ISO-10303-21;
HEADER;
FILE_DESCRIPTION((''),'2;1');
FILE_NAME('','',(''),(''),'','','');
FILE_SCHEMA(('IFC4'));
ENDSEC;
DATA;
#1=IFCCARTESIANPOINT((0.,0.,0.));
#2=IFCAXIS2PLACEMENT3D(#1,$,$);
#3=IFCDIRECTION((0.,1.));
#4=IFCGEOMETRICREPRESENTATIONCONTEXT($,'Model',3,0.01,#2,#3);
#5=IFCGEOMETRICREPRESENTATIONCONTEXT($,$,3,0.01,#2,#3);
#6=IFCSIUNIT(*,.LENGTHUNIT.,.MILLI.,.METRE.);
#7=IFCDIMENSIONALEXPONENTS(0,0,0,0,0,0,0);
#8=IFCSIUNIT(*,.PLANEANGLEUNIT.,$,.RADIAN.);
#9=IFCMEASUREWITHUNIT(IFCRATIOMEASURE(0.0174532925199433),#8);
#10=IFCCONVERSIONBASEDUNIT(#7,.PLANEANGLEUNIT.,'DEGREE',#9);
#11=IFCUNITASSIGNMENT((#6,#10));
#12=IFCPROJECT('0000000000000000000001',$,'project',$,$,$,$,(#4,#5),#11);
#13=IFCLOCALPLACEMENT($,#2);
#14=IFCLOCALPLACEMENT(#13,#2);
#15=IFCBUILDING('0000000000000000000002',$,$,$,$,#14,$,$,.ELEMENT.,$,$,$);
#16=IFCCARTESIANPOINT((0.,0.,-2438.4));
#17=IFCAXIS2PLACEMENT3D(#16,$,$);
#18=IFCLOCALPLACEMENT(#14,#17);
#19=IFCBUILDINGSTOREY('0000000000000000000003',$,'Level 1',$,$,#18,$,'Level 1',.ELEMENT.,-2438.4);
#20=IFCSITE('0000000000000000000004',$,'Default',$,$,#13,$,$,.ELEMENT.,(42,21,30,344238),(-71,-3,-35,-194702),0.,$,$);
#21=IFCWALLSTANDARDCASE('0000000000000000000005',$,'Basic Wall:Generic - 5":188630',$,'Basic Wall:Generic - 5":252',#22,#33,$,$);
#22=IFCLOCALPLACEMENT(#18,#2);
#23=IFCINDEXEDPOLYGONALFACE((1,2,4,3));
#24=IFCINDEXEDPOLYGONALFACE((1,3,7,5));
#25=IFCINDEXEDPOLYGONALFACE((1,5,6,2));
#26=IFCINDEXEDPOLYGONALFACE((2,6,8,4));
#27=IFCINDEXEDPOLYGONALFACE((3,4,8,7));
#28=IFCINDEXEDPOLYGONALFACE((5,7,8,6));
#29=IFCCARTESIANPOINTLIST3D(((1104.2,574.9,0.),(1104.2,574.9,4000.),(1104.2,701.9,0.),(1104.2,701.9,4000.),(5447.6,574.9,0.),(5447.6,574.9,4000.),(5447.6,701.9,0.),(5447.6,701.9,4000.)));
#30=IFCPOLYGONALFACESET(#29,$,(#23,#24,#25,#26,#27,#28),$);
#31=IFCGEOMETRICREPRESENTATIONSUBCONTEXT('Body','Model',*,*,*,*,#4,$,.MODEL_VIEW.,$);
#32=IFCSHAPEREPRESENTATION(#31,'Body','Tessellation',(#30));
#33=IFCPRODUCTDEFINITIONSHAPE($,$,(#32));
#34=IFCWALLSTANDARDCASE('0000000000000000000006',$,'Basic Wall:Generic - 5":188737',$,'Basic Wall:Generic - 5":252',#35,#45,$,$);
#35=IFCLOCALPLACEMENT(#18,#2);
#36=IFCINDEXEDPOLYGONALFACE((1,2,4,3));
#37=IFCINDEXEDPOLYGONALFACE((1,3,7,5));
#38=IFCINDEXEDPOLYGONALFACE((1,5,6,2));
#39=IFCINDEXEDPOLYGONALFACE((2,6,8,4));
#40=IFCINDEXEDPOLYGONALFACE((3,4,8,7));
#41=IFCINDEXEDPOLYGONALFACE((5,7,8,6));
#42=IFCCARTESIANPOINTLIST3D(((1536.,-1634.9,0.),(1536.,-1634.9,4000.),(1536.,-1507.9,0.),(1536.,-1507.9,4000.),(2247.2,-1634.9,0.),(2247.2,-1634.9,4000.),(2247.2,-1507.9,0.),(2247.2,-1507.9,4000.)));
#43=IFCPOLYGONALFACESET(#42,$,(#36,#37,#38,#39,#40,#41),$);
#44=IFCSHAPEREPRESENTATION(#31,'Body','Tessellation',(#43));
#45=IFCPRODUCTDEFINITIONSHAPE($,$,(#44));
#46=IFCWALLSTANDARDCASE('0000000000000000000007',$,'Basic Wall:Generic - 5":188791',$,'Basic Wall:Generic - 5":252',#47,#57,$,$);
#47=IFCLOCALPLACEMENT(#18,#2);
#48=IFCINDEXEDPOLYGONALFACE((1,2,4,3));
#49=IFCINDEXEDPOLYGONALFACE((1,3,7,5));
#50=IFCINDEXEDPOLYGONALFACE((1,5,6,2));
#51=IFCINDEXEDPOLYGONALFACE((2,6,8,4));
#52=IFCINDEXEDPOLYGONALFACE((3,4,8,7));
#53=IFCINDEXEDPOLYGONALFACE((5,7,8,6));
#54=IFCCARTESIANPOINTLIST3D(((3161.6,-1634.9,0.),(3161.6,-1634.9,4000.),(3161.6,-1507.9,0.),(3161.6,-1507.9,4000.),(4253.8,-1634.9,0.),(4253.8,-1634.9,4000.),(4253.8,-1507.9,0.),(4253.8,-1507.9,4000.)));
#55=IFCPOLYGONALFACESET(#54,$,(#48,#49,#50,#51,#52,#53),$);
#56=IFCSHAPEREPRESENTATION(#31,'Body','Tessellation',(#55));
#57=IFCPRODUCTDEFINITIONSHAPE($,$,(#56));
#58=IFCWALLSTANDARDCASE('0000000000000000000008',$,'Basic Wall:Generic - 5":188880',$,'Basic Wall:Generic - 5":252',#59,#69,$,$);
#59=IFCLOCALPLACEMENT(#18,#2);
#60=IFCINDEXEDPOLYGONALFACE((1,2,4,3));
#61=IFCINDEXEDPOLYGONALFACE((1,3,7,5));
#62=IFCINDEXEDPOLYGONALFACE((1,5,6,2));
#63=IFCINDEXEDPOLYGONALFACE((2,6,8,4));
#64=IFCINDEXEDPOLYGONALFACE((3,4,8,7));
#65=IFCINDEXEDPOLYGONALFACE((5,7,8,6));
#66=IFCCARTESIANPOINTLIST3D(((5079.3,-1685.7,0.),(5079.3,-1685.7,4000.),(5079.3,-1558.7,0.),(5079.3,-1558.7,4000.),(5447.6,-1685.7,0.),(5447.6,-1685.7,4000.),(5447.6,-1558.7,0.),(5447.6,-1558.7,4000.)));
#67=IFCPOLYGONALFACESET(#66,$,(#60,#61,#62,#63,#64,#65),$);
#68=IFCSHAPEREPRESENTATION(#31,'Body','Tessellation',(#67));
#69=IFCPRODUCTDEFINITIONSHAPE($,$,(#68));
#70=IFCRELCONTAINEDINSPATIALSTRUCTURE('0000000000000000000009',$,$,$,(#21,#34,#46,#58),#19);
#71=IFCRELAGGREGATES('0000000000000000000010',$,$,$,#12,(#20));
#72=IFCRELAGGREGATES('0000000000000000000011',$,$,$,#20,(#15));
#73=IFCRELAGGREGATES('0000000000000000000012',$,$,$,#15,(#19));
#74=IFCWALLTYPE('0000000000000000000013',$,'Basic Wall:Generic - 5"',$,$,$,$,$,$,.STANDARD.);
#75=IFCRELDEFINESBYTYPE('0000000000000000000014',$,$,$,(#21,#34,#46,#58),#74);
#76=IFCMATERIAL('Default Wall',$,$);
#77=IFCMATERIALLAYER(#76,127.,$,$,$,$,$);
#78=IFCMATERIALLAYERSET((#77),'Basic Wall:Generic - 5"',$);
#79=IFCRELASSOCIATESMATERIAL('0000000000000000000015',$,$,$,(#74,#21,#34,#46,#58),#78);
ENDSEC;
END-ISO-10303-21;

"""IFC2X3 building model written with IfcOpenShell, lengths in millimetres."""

from ifc_helpers import new_model, entity, si_unit, converted_unit, direction, frame, frame_2d, origin, place, context, subcontext, project, spatial, polyline, rectangle, extrude, clip, bounded_halfspace, material, layer, layer_set, layer_usage, type_object, element, save


model = new_model("IFC2X3")

# Units and contexts
model_context = context("Model", 3, precision=0.01, world=origin(), true_north=direction((0.0, 1.0)))
context_of_model = context(None, 3, precision=0.01, world=origin(), true_north=direction((0.0, 1.0)))
body_context = subcontext(model_context, "Body", "Model", "MODEL_VIEW")
ifc_project = project(units=[si_unit("LENGTHUNIT", "METRE", prefix="MILLI"), converted_unit("PLANEANGLEUNIT", "DEGREE", entity("IfcRatioMeasure", 0.0174532925199433), si_unit("PLANEANGLEUNIT", "RADIAN"), dimensions=[0, 0, 0, 0, 0, 0, 0])], contexts=[model_context, context_of_model])

# Site, building, storey
site_placement = place(None, origin())
site = spatial("IfcSite", under=ifc_project, at=site_placement, Name="Default", CompositionType="ELEMENT", RefLatitude=(42, 21, 30, 344238), RefLongitude=(-71, -3, -35, -194702), RefElevation=0.0)
building_placement = place(site_placement, origin())
building = spatial("IfcBuilding", under=site, at=building_placement, CompositionType="ELEMENT")
storey_placement = place(building_placement, frame((0.0, 0.0, -2438.4)))
storey = spatial("IfcBuildingStorey", under=building, at=storey_placement, Name="Level 1", LongName="Level 1", CompositionType="ELEMENT", Elevation=-2438.4)

# Shared definitions
ifc_material_1 = material(Name="Default Wall")
ifc_layer_1 = layer(ifc_material_1, 127.0)
ifc_layer_set_1 = layer_set([ifc_layer_1], Name="Basic Wall:Generic - 5\"")
wall_type = type_object("IfcWallType", Name="Basic Wall:Generic - 5\"", PredefinedType="STANDARD", material=ifc_layer_set_1)

# Walls
ifc_layer_usage_1 = layer_usage(ifc_layer_set_1, "AXIS2", "NEGATIVE", 63.5)
wall_1_placement = place(storey_placement, frame((1104.2, 638.4, 0.0)))
element("IfcWallStandardCase", 1, at=wall_1_placement, inside=storey, type_object=wall_type, material=ifc_layer_usage_1, Name="Basic Wall:Generic - 5\":188630", ObjectType="Basic Wall:Generic - 5\":252", context=body_context, shape_type="Clipping", body=[
    clip(extrude(rectangle(XDim=4343.4, YDim=127.0, at=frame_2d((2171.7, 0.0), x_axis=(-1.0, 0.0))), origin(), (0.0, 0.0, 1.0), 4000.0), bounded_halfspace(frame((0.0, -63.5, 4000.0), z_axis=(0.0, 0.0, -1.0), x_axis=(0.0, -1.0, 0.0)), True, frame((0.0, -63.5, 4000.0)), polyline([(0.0, 0.0), (304.8, 0.0), (431.8, 0.0), (3149.6, 0.0), (3276.6, 0.0), (4343.4, 0.0), (4343.4, 127.0), (0.0, 127.0), (0.0, 0.0)]))),
])
ifc_layer_usage_2 = layer_usage(ifc_layer_set_1, "AXIS2", "NEGATIVE", 63.5)
wall_2_placement = place(storey_placement, frame((2247.2, -1571.4, 0.0), z_axis=(0.0, 0.0, 1.0), x_axis=(-1.0, 0.0, 0.0)))
element("IfcWallStandardCase", 2, at=wall_2_placement, inside=storey, type_object=wall_type, material=ifc_layer_usage_2, Name="Basic Wall:Generic - 5\":188737", ObjectType="Basic Wall:Generic - 5\":252", context=body_context, shape_type="Clipping", body=[
    clip(extrude(rectangle(XDim=711.2, YDim=127.0, at=frame_2d((355.6, 0.0), x_axis=(-1.0, 0.0))), origin(), (0.0, 0.0, 1.0), 4000.0), bounded_halfspace(frame((0.0, -63.5, 4000.0), z_axis=(0.0, 0.0, -1.0), x_axis=(0.0, 1.0, 0.0)), True, frame((0.0, -63.5, 4000.0)), polyline([(0.0, 0.0), (711.2, 0.0), (711.2, 127.0), (0.0, 127.0), (0.0, 0.0)]))),
])
ifc_layer_usage_3 = layer_usage(ifc_layer_set_1, "AXIS2", "POSITIVE", -63.5)
wall_3_placement = place(storey_placement, frame((3161.6, -1571.4, 0.0)))
element("IfcWallStandardCase", 3, at=wall_3_placement, inside=storey, type_object=wall_type, material=ifc_layer_usage_3, Name="Basic Wall:Generic - 5\":188791", ObjectType="Basic Wall:Generic - 5\":252", context=body_context, shape_type="Clipping", body=[
    clip(extrude(rectangle(XDim=1092.2, YDim=127.0, at=frame_2d((546.1, 0.0), x_axis=(-1.0, 0.0))), origin(), (0.0, 0.0, 1.0), 4000.0), bounded_halfspace(frame((0.0, -63.5, 4000.0), z_axis=(0.0, 0.0, -1.0), x_axis=(0.0, -1.0, 0.0)), True, frame((0.0, -63.5, 4000.0)), polyline([(0.0, 0.0), (1092.2, 0.0), (1092.2, 127.0), (0.0, 127.0), (0.0, 0.0)]))),
])
ifc_layer_usage_4 = layer_usage(ifc_layer_set_1, "AXIS2", "NEGATIVE", 63.5)
wall_4_placement = place(storey_placement, frame((5447.6, -1622.2, 0.0), z_axis=(0.0, 0.0, 1.0), x_axis=(-1.0, 0.0, 0.0)))
element("IfcWallStandardCase", 4, at=wall_4_placement, inside=storey, type_object=wall_type, material=ifc_layer_usage_4, Name="Basic Wall:Generic - 5\":188880", ObjectType="Basic Wall:Generic - 5\":252", context=body_context, shape_type="Clipping", body=[
    clip(extrude(rectangle(XDim=368.3, YDim=127.0, at=frame_2d((184.1, 0.0), x_axis=(-1.0, 0.0))), origin(), (0.0, 0.0, 1.0), 4000.0), bounded_halfspace(frame((0.0, -63.5, 4000.0), z_axis=(0.0, 0.0, -1.0), x_axis=(0.0, 1.0, 0.0)), True, frame((0.0, -63.5, 4000.0)), polyline([(0.0, 0.0), (368.3, 0.0), (368.3, 127.0), (0.0, 127.0), (0.0, 0.0)]))),
])

save(model, "model.ifc")
